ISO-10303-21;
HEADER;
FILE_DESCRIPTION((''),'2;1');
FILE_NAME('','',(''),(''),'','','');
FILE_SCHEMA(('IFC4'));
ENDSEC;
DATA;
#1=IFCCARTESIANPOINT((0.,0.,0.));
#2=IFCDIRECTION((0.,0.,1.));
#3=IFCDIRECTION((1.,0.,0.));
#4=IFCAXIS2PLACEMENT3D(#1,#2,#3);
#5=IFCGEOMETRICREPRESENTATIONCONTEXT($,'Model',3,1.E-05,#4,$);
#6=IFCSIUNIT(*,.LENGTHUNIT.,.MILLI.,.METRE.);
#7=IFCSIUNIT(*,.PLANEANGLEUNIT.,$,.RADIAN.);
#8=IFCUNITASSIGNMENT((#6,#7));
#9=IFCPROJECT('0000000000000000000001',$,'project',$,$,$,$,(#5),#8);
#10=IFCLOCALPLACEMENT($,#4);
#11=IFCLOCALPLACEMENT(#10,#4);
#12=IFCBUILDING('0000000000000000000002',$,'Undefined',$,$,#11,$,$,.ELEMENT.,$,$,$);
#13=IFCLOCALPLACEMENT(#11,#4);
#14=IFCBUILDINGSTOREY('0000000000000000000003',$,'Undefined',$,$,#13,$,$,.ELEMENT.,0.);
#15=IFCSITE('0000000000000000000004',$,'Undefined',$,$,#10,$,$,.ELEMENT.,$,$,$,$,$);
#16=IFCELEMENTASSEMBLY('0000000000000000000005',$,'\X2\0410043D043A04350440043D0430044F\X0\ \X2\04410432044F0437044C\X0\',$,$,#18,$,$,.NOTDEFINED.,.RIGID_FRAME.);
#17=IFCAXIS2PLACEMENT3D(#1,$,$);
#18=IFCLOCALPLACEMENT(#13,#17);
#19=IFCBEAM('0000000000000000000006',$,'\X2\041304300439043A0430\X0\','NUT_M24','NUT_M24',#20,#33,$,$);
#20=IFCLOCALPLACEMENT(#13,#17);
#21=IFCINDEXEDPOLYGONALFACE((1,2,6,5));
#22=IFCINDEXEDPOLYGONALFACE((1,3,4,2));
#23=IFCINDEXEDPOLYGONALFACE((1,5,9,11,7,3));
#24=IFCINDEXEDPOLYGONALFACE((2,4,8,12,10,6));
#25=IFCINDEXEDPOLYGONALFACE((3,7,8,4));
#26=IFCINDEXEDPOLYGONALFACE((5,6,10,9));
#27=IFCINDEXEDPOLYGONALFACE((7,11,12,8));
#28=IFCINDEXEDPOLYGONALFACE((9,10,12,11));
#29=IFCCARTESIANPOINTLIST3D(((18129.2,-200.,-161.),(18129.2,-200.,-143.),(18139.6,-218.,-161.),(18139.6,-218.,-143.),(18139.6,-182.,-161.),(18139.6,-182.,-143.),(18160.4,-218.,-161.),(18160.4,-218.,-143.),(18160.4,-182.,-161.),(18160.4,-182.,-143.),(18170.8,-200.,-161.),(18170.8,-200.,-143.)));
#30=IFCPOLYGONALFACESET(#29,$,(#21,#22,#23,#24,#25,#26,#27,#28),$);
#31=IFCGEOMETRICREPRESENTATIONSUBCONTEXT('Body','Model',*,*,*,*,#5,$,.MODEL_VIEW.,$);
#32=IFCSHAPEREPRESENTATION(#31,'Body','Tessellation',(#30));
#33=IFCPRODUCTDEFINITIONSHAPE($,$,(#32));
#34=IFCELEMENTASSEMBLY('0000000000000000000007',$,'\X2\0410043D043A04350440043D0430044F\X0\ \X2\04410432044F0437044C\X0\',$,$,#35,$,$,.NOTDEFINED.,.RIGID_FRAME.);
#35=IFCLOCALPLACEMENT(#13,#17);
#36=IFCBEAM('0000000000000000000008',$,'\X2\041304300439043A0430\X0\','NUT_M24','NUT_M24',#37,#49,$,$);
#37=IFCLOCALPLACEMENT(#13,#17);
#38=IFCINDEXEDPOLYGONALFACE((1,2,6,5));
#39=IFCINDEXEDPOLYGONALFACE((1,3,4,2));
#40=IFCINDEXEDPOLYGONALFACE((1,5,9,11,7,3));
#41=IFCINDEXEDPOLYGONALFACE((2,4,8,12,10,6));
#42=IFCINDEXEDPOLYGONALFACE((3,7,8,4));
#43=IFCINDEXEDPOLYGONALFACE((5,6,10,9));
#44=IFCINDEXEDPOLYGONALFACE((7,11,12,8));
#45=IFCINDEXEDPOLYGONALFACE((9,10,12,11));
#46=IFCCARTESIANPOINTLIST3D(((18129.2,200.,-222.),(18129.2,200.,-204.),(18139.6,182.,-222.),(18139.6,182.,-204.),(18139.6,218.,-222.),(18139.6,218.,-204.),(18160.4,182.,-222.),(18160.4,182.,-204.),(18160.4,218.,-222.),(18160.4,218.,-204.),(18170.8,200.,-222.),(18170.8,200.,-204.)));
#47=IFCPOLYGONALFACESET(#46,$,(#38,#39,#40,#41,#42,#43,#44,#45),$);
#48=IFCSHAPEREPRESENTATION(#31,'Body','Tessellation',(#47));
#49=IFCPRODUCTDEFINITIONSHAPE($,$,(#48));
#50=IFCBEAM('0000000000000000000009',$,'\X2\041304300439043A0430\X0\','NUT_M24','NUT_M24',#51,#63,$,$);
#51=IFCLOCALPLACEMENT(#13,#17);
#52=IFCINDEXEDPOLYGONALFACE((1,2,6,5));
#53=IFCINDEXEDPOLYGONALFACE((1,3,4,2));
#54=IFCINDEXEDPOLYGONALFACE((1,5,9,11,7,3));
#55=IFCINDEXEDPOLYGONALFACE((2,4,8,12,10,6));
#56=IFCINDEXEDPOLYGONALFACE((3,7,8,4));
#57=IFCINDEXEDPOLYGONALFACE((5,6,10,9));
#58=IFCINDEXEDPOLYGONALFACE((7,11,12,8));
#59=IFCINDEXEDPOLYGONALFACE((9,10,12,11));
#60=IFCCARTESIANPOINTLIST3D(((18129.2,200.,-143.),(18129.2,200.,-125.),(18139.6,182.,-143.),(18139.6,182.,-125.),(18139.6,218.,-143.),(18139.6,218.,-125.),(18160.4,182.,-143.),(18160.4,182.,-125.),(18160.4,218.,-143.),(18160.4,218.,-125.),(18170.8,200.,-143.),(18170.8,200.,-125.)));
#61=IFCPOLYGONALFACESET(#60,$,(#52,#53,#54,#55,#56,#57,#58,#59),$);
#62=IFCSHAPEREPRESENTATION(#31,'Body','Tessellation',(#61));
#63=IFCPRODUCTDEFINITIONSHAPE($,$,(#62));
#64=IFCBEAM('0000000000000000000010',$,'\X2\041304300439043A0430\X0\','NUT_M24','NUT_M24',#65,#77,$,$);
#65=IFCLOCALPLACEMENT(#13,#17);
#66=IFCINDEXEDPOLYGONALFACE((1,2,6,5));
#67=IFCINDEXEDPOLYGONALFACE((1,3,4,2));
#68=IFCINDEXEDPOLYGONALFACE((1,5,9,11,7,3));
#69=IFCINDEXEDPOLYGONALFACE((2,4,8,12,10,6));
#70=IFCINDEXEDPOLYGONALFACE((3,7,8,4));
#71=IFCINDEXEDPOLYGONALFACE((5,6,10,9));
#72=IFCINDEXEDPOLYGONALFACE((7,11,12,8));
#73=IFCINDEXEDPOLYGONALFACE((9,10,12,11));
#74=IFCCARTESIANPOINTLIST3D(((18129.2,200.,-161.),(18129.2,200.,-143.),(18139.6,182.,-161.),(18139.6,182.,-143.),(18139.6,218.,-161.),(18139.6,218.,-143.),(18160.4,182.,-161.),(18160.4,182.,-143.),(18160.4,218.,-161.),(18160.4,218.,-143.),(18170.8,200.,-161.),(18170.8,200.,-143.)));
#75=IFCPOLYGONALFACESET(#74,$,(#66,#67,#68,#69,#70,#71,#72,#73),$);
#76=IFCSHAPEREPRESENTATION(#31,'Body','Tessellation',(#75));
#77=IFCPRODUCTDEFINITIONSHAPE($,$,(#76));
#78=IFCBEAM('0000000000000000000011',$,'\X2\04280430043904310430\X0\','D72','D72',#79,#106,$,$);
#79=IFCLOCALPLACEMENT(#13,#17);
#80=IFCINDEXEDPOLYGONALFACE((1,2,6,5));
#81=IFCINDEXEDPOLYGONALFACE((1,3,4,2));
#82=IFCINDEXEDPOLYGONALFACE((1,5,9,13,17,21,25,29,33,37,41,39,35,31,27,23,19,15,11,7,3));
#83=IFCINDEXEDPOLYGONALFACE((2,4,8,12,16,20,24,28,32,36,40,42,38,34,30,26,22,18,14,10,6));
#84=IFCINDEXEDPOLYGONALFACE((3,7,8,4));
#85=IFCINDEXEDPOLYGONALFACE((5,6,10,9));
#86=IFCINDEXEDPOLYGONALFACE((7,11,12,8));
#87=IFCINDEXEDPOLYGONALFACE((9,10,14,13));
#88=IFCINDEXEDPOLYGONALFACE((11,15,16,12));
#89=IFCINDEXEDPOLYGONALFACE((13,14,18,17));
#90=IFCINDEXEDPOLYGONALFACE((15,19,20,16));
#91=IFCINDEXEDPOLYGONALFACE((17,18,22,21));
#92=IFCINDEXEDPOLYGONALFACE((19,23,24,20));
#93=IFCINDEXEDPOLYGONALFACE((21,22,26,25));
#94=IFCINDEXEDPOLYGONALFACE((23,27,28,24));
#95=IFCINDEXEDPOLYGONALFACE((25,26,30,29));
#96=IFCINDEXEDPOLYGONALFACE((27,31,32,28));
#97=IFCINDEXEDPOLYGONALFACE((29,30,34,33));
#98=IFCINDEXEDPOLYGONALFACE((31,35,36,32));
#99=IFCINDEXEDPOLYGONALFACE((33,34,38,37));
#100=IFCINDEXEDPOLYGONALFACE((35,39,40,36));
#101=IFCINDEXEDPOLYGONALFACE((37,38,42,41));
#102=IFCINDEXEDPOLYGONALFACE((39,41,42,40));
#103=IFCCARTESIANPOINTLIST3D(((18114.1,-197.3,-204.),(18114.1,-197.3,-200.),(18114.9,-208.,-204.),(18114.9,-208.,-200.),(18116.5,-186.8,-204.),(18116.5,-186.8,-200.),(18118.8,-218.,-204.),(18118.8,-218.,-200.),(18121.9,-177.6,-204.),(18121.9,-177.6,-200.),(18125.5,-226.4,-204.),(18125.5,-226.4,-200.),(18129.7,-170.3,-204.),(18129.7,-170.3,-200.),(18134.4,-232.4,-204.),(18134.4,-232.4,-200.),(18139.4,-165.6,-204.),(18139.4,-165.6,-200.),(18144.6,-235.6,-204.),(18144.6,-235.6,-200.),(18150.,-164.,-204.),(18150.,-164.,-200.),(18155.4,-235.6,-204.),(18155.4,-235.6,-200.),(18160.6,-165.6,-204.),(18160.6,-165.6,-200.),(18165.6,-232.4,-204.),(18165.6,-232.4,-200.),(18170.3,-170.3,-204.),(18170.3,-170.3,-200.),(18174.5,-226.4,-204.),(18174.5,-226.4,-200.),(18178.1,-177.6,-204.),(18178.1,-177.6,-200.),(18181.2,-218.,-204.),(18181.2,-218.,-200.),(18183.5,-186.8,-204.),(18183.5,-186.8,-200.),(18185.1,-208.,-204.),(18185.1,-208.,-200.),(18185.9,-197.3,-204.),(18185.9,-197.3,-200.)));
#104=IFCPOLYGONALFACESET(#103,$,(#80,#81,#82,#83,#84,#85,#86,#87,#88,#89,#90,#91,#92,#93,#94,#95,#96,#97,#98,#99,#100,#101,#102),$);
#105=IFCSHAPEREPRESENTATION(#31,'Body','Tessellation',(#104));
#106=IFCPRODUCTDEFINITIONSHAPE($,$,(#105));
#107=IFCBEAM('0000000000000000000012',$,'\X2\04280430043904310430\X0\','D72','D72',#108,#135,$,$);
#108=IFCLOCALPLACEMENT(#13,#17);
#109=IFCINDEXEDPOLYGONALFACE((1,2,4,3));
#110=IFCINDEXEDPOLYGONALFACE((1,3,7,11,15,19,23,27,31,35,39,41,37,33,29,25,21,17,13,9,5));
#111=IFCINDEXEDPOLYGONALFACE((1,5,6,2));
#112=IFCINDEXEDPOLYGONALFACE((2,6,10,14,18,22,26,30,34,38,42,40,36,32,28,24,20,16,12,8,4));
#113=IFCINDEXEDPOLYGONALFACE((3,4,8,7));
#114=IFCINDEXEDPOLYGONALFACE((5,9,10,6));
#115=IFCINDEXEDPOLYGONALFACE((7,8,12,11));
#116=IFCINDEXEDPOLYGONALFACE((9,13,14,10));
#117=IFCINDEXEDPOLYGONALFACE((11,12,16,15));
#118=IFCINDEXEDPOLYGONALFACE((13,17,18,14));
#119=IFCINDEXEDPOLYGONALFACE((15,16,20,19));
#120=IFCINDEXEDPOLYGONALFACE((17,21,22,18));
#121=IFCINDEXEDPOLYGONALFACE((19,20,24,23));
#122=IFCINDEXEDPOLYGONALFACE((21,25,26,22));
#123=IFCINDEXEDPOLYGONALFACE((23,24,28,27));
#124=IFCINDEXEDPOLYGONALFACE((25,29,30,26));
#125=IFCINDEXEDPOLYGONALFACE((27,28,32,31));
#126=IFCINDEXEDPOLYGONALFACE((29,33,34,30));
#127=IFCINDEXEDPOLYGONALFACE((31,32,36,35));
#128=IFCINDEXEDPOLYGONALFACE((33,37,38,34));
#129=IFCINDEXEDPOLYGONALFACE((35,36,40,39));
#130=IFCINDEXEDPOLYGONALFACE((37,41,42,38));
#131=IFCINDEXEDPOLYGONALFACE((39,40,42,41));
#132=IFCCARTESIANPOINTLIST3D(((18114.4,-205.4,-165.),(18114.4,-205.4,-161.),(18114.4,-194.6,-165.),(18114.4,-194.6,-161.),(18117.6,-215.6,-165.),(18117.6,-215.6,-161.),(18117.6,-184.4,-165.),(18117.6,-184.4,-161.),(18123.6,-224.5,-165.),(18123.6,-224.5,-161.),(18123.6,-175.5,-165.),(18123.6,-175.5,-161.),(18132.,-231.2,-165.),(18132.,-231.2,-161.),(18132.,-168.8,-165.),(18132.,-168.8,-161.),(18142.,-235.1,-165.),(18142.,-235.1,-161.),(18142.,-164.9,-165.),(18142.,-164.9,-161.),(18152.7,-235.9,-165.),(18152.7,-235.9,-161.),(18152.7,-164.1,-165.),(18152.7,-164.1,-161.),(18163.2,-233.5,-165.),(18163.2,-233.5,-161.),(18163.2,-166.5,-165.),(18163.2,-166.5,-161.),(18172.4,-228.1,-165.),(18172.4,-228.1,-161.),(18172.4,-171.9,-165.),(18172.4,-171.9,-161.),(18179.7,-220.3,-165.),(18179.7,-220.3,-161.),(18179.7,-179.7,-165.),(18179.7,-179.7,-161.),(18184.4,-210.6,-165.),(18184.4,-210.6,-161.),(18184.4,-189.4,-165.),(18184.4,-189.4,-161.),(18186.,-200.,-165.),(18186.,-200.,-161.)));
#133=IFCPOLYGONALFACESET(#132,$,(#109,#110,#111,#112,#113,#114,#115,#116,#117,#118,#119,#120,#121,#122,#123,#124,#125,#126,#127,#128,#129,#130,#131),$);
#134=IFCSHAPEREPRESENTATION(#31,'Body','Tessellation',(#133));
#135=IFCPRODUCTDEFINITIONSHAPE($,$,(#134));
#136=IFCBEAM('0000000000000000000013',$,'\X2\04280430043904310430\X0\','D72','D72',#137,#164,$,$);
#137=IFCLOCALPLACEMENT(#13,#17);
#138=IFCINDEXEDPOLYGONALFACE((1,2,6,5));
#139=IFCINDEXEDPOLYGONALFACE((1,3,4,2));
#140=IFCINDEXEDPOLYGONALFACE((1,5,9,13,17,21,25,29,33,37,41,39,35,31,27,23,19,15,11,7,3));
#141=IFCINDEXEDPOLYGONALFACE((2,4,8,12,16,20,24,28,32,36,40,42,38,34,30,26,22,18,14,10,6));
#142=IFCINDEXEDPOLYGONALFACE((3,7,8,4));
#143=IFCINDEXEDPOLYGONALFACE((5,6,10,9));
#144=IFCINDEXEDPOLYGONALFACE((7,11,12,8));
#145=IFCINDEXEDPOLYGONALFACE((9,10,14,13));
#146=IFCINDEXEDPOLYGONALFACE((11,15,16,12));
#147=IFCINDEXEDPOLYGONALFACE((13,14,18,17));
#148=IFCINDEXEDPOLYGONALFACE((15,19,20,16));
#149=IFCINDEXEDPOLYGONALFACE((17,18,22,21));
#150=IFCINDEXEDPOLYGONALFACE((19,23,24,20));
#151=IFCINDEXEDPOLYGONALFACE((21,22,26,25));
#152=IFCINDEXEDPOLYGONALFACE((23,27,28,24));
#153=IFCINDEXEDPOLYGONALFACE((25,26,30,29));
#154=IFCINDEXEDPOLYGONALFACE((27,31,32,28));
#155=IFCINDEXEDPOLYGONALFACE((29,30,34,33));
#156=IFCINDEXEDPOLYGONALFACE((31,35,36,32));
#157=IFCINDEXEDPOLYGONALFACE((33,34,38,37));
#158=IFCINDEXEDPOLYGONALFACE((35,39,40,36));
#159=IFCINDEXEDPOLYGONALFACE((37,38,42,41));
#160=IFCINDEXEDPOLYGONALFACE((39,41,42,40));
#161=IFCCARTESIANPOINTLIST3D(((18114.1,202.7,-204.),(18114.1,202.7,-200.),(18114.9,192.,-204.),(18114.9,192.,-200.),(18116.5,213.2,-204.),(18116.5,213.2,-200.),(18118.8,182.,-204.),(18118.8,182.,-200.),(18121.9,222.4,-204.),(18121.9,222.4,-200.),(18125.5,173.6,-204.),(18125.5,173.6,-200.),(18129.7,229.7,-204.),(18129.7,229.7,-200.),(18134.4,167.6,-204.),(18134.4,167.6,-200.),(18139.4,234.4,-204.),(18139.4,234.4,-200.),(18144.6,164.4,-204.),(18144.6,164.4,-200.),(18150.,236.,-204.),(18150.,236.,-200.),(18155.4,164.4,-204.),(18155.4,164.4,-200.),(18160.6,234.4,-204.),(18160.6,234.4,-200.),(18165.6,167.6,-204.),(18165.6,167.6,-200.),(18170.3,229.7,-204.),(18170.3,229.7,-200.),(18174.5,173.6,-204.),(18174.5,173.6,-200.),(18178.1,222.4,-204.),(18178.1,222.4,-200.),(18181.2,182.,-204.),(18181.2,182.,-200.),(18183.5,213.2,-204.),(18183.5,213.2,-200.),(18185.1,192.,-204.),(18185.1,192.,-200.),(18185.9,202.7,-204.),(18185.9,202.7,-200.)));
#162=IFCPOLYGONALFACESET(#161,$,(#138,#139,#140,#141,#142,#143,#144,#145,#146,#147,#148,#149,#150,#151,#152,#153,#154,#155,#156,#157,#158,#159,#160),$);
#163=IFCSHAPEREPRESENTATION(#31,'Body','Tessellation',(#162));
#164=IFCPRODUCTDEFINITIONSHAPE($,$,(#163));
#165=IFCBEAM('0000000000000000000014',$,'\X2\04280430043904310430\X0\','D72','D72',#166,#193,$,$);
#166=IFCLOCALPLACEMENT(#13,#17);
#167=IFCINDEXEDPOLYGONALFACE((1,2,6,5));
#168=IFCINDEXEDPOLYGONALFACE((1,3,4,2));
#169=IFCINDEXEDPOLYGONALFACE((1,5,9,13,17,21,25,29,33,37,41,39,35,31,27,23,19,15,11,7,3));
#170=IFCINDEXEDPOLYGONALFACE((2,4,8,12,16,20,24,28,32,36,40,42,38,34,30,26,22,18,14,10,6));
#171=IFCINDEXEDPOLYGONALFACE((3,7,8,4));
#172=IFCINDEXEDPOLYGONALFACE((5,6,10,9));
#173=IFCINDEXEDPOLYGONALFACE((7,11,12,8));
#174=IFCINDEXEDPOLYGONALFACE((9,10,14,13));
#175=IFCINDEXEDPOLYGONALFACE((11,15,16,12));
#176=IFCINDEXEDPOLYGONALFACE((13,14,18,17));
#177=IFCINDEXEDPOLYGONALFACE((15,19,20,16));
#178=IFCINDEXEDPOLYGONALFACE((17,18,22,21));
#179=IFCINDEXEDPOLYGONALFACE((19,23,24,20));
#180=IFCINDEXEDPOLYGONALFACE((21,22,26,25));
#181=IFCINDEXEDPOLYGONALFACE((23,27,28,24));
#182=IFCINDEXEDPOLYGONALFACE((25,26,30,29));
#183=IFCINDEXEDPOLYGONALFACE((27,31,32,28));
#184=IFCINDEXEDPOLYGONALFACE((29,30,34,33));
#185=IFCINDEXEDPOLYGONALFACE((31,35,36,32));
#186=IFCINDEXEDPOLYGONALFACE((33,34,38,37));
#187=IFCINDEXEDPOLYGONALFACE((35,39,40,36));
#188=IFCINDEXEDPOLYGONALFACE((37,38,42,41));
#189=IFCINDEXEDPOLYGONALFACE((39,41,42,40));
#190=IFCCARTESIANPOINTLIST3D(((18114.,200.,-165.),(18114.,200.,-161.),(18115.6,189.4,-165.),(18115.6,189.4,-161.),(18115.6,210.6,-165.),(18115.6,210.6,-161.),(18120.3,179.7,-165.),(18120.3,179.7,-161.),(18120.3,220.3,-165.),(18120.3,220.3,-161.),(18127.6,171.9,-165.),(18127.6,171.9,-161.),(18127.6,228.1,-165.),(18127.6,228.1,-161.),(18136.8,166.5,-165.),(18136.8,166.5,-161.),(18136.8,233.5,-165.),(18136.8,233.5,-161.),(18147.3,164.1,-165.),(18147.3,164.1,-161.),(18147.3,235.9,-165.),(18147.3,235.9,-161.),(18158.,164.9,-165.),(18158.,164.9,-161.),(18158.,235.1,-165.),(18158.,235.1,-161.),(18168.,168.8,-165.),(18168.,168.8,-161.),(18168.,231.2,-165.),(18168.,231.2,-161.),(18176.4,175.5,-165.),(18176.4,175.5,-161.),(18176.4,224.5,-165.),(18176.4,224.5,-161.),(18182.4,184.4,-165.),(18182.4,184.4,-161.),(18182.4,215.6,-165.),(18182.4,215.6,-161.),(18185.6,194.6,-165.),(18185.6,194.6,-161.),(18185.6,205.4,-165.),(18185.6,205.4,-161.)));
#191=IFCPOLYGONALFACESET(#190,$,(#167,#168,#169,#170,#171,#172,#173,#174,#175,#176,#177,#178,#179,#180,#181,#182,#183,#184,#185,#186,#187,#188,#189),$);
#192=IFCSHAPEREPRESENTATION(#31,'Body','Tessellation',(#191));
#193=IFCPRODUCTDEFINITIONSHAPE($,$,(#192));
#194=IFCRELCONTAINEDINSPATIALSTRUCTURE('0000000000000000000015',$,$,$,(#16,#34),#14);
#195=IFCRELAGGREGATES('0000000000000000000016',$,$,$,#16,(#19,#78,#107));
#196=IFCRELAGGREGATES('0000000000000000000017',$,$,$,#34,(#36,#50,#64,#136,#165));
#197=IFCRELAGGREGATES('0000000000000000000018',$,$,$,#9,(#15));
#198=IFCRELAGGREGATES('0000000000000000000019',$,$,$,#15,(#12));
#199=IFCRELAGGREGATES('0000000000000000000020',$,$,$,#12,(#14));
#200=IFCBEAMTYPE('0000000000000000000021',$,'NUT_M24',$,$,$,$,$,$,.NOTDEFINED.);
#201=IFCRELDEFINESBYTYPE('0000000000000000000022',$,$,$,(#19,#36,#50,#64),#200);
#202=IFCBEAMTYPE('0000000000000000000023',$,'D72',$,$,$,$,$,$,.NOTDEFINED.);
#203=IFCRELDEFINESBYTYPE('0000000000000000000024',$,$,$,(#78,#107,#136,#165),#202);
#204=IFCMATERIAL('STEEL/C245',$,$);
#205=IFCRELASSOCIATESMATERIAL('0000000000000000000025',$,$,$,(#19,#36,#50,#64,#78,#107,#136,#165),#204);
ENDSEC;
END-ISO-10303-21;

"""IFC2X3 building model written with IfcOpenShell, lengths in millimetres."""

from ifc_helpers import new_model, si_unit, frame, origin_with_axes, origin_2d_with_axis, place, context, subcontext, project, spatial, polyline, circle, outline, extrude, material, type_object, element, aggregate, save


model = new_model("IFC2X3")

# Units and contexts
model_context = context("Model", 3, precision=1e-05, world=origin_with_axes())
body_context = subcontext(model_context, "Body", "Model", "MODEL_VIEW")
ifc_project = project(units=[si_unit("LENGTHUNIT", "METRE", prefix="MILLI"), si_unit("PLANEANGLEUNIT", "RADIAN")], contexts=[model_context])

# Site, building, storey
site_placement = place(None, origin_with_axes())
site = spatial("IfcSite", under=ifc_project, at=site_placement, Name="Undefined", CompositionType="ELEMENT")
building_placement = place(site_placement, origin_with_axes())
building = spatial("IfcBuilding", under=site, at=building_placement, Name="Undefined", CompositionType="ELEMENT")
storey_placement = place(building_placement, origin_with_axes())
storey = spatial("IfcBuildingStorey", under=building, at=storey_placement, Name="Undefined", CompositionType="ELEMENT", Elevation=0.0)

# Shared definitions
ifc_material_1 = material(Name="STEEL/C245")

# Element assemblies, beams
assembly_1_placement = place(storey_placement, origin_with_axes())
assembly_1 = element("IfcElementAssembly", 1, at=assembly_1_placement, inside=storey, Name="Анкерная связь", AssemblyPlace="NOTDEFINED", PredefinedType="RIGID_FRAME")
beam_type_1 = type_object("IfcBeamType", Name="NUT_M24", PredefinedType="NOTDEFINED")
beam_1_placement = place(assembly_1_placement, frame((18150.0, -200.0, -143.0), z_axis=(0.0, 1.0, 0.0), x_axis=(0.0, 0.0, -1.0)))
beam_1 = element("IfcBeam", 2, at=beam_1_placement, type_object=beam_type_1, material=ifc_material_1, Name="Гайка", Description="NUT_M24", ObjectType="NUT_M24", context=body_context, shape_type="SweptSolid", body=[
    extrude(outline(polyline([(-10.4, 18.0), (10.4, 18.0), (20.8, 0.0), (10.4, -18.0), (-10.4, -18.0), (-20.8, 0.0), (-10.4, 18.0)])), frame((18.0, 0.0, 0.0), z_axis=(-1.0, 0.0, 0.0), x_axis=(0.0, -1.0, 0.0)), (0.0, 0.0, 1.0), 18.0),
])
assembly_2_placement = place(storey_placement, origin_with_axes())
assembly_2 = element("IfcElementAssembly", 3, at=assembly_2_placement, inside=storey, Name="Анкерная связь", AssemblyPlace="NOTDEFINED", PredefinedType="RIGID_FRAME")
beam_2_placement = place(assembly_2_placement, frame((18150.0, 200.0, -204.0), z_axis=(0.0, 1.0, 0.0), x_axis=(0.0, 0.0, -1.0)))
beam_2 = element("IfcBeam", 4, at=beam_2_placement, type_object=beam_type_1, material=ifc_material_1, Name="Гайка", Description="NUT_M24", ObjectType="NUT_M24", context=body_context, shape_type="SweptSolid", body=[
    extrude(outline(polyline([(-10.4, 18.0), (10.4, 18.0), (20.8, 0.0), (10.4, -18.0), (-10.4, -18.0), (-20.8, 0.0), (-10.4, 18.0)])), frame((18.0, 0.0, 0.0), z_axis=(-1.0, 0.0, 0.0), x_axis=(0.0, -1.0, 0.0)), (0.0, 0.0, 1.0), 18.0),
])
beam_3_placement = place(assembly_2_placement, frame((18150.0, 200.0, -125.0), z_axis=(0.0, 1.0, 0.0), x_axis=(0.0, 0.0, -1.0)))
beam_3 = element("IfcBeam", 5, at=beam_3_placement, type_object=beam_type_1, material=ifc_material_1, Name="Гайка", Description="NUT_M24", ObjectType="NUT_M24", context=body_context, shape_type="SweptSolid", body=[
    extrude(outline(polyline([(-10.4, 18.0), (10.4, 18.0), (20.8, 0.0), (10.4, -18.0), (-10.4, -18.0), (-20.8, 0.0), (-10.4, 18.0)])), frame((18.0, 0.0, 0.0), z_axis=(-1.0, 0.0, 0.0), x_axis=(0.0, -1.0, 0.0)), (0.0, 0.0, 1.0), 18.0),
])
beam_4_placement = place(assembly_2_placement, frame((18150.0, 200.0, -143.0), z_axis=(0.0, 1.0, 0.0), x_axis=(0.0, 0.0, -1.0)))
beam_4 = element("IfcBeam", 6, at=beam_4_placement, type_object=beam_type_1, material=ifc_material_1, Name="Гайка", Description="NUT_M24", ObjectType="NUT_M24", context=body_context, shape_type="SweptSolid", body=[
    extrude(outline(polyline([(-10.4, 18.0), (10.4, 18.0), (20.8, 0.0), (10.4, -18.0), (-10.4, -18.0), (-20.8, 0.0), (-10.4, 18.0)])), frame((18.0, 0.0, 0.0), z_axis=(-1.0, 0.0, 0.0), x_axis=(0.0, -1.0, 0.0)), (0.0, 0.0, 1.0), 18.0),
])

# Beams
beam_type_2 = type_object("IfcBeamType", Name="D72", PredefinedType="NOTDEFINED")
beam_5_placement = place(assembly_1_placement, frame((18150.0, -200.0, -200.0), z_axis=(-1.0, 0.0, 0.0), x_axis=(0.0, 0.0, -1.0)))
beam_5 = element("IfcBeam", 7, at=beam_5_placement, type_object=beam_type_2, material=ifc_material_1, Name="Шайба", Description="D72", ObjectType="D72", context=body_context, shape_type="SweptSolid", body=[
    extrude(circle(Radius=36.0, at=origin_2d_with_axis()), frame((4.0, 0.0, 0.0), z_axis=(-1.0, 0.0, 0.0), x_axis=(0.0, -1.0, 0.0)), (0.0, 0.0, 1.0), 4.0),
])
beam_6_placement = place(assembly_1_placement, frame((18150.0, -200.0, -161.0), z_axis=(0.0, 1.0, 0.0), x_axis=(0.0, 0.0, -1.0)))
beam_6 = element("IfcBeam", 8, at=beam_6_placement, type_object=beam_type_2, material=ifc_material_1, Name="Шайба", Description="D72", ObjectType="D72", context=body_context, shape_type="SweptSolid", body=[
    extrude(circle(Radius=36.0, at=origin_2d_with_axis()), frame((4.0, 0.0, 0.0), z_axis=(-1.0, 0.0, 0.0), x_axis=(0.0, -1.0, 0.0)), (0.0, 0.0, 1.0), 4.0),
])
beam_7_placement = place(assembly_2_placement, frame((18150.0, 200.0, -200.0), z_axis=(-1.0, 0.0, 0.0), x_axis=(0.0, 0.0, -1.0)))
beam_7 = element("IfcBeam", 9, at=beam_7_placement, type_object=beam_type_2, material=ifc_material_1, Name="Шайба", Description="D72", ObjectType="D72", context=body_context, shape_type="SweptSolid", body=[
    extrude(circle(Radius=36.0, at=origin_2d_with_axis()), frame((4.0, 0.0, 0.0), z_axis=(-1.0, 0.0, 0.0), x_axis=(0.0, -1.0, 0.0)), (0.0, 0.0, 1.0), 4.0),
])
beam_8_placement = place(assembly_2_placement, frame((18150.0, 200.0, -161.0), z_axis=(0.0, -1.0, 0.0), x_axis=(0.0, 0.0, -1.0)))
beam_8 = element("IfcBeam", 10, at=beam_8_placement, type_object=beam_type_2, material=ifc_material_1, Name="Шайба", Description="D72", ObjectType="D72", context=body_context, shape_type="SweptSolid", body=[
    extrude(circle(Radius=36.0, at=origin_2d_with_axis()), frame((4.0, 0.0, 0.0), z_axis=(-1.0, 0.0, 0.0), x_axis=(0.0, -1.0, 0.0)), (0.0, 0.0, 1.0), 4.0),
])

aggregate(assembly_1, [beam_1, beam_5, beam_6])
aggregate(assembly_2, [beam_2, beam_3, beam_4, beam_7, beam_8])

save(model, "model.ifc")
